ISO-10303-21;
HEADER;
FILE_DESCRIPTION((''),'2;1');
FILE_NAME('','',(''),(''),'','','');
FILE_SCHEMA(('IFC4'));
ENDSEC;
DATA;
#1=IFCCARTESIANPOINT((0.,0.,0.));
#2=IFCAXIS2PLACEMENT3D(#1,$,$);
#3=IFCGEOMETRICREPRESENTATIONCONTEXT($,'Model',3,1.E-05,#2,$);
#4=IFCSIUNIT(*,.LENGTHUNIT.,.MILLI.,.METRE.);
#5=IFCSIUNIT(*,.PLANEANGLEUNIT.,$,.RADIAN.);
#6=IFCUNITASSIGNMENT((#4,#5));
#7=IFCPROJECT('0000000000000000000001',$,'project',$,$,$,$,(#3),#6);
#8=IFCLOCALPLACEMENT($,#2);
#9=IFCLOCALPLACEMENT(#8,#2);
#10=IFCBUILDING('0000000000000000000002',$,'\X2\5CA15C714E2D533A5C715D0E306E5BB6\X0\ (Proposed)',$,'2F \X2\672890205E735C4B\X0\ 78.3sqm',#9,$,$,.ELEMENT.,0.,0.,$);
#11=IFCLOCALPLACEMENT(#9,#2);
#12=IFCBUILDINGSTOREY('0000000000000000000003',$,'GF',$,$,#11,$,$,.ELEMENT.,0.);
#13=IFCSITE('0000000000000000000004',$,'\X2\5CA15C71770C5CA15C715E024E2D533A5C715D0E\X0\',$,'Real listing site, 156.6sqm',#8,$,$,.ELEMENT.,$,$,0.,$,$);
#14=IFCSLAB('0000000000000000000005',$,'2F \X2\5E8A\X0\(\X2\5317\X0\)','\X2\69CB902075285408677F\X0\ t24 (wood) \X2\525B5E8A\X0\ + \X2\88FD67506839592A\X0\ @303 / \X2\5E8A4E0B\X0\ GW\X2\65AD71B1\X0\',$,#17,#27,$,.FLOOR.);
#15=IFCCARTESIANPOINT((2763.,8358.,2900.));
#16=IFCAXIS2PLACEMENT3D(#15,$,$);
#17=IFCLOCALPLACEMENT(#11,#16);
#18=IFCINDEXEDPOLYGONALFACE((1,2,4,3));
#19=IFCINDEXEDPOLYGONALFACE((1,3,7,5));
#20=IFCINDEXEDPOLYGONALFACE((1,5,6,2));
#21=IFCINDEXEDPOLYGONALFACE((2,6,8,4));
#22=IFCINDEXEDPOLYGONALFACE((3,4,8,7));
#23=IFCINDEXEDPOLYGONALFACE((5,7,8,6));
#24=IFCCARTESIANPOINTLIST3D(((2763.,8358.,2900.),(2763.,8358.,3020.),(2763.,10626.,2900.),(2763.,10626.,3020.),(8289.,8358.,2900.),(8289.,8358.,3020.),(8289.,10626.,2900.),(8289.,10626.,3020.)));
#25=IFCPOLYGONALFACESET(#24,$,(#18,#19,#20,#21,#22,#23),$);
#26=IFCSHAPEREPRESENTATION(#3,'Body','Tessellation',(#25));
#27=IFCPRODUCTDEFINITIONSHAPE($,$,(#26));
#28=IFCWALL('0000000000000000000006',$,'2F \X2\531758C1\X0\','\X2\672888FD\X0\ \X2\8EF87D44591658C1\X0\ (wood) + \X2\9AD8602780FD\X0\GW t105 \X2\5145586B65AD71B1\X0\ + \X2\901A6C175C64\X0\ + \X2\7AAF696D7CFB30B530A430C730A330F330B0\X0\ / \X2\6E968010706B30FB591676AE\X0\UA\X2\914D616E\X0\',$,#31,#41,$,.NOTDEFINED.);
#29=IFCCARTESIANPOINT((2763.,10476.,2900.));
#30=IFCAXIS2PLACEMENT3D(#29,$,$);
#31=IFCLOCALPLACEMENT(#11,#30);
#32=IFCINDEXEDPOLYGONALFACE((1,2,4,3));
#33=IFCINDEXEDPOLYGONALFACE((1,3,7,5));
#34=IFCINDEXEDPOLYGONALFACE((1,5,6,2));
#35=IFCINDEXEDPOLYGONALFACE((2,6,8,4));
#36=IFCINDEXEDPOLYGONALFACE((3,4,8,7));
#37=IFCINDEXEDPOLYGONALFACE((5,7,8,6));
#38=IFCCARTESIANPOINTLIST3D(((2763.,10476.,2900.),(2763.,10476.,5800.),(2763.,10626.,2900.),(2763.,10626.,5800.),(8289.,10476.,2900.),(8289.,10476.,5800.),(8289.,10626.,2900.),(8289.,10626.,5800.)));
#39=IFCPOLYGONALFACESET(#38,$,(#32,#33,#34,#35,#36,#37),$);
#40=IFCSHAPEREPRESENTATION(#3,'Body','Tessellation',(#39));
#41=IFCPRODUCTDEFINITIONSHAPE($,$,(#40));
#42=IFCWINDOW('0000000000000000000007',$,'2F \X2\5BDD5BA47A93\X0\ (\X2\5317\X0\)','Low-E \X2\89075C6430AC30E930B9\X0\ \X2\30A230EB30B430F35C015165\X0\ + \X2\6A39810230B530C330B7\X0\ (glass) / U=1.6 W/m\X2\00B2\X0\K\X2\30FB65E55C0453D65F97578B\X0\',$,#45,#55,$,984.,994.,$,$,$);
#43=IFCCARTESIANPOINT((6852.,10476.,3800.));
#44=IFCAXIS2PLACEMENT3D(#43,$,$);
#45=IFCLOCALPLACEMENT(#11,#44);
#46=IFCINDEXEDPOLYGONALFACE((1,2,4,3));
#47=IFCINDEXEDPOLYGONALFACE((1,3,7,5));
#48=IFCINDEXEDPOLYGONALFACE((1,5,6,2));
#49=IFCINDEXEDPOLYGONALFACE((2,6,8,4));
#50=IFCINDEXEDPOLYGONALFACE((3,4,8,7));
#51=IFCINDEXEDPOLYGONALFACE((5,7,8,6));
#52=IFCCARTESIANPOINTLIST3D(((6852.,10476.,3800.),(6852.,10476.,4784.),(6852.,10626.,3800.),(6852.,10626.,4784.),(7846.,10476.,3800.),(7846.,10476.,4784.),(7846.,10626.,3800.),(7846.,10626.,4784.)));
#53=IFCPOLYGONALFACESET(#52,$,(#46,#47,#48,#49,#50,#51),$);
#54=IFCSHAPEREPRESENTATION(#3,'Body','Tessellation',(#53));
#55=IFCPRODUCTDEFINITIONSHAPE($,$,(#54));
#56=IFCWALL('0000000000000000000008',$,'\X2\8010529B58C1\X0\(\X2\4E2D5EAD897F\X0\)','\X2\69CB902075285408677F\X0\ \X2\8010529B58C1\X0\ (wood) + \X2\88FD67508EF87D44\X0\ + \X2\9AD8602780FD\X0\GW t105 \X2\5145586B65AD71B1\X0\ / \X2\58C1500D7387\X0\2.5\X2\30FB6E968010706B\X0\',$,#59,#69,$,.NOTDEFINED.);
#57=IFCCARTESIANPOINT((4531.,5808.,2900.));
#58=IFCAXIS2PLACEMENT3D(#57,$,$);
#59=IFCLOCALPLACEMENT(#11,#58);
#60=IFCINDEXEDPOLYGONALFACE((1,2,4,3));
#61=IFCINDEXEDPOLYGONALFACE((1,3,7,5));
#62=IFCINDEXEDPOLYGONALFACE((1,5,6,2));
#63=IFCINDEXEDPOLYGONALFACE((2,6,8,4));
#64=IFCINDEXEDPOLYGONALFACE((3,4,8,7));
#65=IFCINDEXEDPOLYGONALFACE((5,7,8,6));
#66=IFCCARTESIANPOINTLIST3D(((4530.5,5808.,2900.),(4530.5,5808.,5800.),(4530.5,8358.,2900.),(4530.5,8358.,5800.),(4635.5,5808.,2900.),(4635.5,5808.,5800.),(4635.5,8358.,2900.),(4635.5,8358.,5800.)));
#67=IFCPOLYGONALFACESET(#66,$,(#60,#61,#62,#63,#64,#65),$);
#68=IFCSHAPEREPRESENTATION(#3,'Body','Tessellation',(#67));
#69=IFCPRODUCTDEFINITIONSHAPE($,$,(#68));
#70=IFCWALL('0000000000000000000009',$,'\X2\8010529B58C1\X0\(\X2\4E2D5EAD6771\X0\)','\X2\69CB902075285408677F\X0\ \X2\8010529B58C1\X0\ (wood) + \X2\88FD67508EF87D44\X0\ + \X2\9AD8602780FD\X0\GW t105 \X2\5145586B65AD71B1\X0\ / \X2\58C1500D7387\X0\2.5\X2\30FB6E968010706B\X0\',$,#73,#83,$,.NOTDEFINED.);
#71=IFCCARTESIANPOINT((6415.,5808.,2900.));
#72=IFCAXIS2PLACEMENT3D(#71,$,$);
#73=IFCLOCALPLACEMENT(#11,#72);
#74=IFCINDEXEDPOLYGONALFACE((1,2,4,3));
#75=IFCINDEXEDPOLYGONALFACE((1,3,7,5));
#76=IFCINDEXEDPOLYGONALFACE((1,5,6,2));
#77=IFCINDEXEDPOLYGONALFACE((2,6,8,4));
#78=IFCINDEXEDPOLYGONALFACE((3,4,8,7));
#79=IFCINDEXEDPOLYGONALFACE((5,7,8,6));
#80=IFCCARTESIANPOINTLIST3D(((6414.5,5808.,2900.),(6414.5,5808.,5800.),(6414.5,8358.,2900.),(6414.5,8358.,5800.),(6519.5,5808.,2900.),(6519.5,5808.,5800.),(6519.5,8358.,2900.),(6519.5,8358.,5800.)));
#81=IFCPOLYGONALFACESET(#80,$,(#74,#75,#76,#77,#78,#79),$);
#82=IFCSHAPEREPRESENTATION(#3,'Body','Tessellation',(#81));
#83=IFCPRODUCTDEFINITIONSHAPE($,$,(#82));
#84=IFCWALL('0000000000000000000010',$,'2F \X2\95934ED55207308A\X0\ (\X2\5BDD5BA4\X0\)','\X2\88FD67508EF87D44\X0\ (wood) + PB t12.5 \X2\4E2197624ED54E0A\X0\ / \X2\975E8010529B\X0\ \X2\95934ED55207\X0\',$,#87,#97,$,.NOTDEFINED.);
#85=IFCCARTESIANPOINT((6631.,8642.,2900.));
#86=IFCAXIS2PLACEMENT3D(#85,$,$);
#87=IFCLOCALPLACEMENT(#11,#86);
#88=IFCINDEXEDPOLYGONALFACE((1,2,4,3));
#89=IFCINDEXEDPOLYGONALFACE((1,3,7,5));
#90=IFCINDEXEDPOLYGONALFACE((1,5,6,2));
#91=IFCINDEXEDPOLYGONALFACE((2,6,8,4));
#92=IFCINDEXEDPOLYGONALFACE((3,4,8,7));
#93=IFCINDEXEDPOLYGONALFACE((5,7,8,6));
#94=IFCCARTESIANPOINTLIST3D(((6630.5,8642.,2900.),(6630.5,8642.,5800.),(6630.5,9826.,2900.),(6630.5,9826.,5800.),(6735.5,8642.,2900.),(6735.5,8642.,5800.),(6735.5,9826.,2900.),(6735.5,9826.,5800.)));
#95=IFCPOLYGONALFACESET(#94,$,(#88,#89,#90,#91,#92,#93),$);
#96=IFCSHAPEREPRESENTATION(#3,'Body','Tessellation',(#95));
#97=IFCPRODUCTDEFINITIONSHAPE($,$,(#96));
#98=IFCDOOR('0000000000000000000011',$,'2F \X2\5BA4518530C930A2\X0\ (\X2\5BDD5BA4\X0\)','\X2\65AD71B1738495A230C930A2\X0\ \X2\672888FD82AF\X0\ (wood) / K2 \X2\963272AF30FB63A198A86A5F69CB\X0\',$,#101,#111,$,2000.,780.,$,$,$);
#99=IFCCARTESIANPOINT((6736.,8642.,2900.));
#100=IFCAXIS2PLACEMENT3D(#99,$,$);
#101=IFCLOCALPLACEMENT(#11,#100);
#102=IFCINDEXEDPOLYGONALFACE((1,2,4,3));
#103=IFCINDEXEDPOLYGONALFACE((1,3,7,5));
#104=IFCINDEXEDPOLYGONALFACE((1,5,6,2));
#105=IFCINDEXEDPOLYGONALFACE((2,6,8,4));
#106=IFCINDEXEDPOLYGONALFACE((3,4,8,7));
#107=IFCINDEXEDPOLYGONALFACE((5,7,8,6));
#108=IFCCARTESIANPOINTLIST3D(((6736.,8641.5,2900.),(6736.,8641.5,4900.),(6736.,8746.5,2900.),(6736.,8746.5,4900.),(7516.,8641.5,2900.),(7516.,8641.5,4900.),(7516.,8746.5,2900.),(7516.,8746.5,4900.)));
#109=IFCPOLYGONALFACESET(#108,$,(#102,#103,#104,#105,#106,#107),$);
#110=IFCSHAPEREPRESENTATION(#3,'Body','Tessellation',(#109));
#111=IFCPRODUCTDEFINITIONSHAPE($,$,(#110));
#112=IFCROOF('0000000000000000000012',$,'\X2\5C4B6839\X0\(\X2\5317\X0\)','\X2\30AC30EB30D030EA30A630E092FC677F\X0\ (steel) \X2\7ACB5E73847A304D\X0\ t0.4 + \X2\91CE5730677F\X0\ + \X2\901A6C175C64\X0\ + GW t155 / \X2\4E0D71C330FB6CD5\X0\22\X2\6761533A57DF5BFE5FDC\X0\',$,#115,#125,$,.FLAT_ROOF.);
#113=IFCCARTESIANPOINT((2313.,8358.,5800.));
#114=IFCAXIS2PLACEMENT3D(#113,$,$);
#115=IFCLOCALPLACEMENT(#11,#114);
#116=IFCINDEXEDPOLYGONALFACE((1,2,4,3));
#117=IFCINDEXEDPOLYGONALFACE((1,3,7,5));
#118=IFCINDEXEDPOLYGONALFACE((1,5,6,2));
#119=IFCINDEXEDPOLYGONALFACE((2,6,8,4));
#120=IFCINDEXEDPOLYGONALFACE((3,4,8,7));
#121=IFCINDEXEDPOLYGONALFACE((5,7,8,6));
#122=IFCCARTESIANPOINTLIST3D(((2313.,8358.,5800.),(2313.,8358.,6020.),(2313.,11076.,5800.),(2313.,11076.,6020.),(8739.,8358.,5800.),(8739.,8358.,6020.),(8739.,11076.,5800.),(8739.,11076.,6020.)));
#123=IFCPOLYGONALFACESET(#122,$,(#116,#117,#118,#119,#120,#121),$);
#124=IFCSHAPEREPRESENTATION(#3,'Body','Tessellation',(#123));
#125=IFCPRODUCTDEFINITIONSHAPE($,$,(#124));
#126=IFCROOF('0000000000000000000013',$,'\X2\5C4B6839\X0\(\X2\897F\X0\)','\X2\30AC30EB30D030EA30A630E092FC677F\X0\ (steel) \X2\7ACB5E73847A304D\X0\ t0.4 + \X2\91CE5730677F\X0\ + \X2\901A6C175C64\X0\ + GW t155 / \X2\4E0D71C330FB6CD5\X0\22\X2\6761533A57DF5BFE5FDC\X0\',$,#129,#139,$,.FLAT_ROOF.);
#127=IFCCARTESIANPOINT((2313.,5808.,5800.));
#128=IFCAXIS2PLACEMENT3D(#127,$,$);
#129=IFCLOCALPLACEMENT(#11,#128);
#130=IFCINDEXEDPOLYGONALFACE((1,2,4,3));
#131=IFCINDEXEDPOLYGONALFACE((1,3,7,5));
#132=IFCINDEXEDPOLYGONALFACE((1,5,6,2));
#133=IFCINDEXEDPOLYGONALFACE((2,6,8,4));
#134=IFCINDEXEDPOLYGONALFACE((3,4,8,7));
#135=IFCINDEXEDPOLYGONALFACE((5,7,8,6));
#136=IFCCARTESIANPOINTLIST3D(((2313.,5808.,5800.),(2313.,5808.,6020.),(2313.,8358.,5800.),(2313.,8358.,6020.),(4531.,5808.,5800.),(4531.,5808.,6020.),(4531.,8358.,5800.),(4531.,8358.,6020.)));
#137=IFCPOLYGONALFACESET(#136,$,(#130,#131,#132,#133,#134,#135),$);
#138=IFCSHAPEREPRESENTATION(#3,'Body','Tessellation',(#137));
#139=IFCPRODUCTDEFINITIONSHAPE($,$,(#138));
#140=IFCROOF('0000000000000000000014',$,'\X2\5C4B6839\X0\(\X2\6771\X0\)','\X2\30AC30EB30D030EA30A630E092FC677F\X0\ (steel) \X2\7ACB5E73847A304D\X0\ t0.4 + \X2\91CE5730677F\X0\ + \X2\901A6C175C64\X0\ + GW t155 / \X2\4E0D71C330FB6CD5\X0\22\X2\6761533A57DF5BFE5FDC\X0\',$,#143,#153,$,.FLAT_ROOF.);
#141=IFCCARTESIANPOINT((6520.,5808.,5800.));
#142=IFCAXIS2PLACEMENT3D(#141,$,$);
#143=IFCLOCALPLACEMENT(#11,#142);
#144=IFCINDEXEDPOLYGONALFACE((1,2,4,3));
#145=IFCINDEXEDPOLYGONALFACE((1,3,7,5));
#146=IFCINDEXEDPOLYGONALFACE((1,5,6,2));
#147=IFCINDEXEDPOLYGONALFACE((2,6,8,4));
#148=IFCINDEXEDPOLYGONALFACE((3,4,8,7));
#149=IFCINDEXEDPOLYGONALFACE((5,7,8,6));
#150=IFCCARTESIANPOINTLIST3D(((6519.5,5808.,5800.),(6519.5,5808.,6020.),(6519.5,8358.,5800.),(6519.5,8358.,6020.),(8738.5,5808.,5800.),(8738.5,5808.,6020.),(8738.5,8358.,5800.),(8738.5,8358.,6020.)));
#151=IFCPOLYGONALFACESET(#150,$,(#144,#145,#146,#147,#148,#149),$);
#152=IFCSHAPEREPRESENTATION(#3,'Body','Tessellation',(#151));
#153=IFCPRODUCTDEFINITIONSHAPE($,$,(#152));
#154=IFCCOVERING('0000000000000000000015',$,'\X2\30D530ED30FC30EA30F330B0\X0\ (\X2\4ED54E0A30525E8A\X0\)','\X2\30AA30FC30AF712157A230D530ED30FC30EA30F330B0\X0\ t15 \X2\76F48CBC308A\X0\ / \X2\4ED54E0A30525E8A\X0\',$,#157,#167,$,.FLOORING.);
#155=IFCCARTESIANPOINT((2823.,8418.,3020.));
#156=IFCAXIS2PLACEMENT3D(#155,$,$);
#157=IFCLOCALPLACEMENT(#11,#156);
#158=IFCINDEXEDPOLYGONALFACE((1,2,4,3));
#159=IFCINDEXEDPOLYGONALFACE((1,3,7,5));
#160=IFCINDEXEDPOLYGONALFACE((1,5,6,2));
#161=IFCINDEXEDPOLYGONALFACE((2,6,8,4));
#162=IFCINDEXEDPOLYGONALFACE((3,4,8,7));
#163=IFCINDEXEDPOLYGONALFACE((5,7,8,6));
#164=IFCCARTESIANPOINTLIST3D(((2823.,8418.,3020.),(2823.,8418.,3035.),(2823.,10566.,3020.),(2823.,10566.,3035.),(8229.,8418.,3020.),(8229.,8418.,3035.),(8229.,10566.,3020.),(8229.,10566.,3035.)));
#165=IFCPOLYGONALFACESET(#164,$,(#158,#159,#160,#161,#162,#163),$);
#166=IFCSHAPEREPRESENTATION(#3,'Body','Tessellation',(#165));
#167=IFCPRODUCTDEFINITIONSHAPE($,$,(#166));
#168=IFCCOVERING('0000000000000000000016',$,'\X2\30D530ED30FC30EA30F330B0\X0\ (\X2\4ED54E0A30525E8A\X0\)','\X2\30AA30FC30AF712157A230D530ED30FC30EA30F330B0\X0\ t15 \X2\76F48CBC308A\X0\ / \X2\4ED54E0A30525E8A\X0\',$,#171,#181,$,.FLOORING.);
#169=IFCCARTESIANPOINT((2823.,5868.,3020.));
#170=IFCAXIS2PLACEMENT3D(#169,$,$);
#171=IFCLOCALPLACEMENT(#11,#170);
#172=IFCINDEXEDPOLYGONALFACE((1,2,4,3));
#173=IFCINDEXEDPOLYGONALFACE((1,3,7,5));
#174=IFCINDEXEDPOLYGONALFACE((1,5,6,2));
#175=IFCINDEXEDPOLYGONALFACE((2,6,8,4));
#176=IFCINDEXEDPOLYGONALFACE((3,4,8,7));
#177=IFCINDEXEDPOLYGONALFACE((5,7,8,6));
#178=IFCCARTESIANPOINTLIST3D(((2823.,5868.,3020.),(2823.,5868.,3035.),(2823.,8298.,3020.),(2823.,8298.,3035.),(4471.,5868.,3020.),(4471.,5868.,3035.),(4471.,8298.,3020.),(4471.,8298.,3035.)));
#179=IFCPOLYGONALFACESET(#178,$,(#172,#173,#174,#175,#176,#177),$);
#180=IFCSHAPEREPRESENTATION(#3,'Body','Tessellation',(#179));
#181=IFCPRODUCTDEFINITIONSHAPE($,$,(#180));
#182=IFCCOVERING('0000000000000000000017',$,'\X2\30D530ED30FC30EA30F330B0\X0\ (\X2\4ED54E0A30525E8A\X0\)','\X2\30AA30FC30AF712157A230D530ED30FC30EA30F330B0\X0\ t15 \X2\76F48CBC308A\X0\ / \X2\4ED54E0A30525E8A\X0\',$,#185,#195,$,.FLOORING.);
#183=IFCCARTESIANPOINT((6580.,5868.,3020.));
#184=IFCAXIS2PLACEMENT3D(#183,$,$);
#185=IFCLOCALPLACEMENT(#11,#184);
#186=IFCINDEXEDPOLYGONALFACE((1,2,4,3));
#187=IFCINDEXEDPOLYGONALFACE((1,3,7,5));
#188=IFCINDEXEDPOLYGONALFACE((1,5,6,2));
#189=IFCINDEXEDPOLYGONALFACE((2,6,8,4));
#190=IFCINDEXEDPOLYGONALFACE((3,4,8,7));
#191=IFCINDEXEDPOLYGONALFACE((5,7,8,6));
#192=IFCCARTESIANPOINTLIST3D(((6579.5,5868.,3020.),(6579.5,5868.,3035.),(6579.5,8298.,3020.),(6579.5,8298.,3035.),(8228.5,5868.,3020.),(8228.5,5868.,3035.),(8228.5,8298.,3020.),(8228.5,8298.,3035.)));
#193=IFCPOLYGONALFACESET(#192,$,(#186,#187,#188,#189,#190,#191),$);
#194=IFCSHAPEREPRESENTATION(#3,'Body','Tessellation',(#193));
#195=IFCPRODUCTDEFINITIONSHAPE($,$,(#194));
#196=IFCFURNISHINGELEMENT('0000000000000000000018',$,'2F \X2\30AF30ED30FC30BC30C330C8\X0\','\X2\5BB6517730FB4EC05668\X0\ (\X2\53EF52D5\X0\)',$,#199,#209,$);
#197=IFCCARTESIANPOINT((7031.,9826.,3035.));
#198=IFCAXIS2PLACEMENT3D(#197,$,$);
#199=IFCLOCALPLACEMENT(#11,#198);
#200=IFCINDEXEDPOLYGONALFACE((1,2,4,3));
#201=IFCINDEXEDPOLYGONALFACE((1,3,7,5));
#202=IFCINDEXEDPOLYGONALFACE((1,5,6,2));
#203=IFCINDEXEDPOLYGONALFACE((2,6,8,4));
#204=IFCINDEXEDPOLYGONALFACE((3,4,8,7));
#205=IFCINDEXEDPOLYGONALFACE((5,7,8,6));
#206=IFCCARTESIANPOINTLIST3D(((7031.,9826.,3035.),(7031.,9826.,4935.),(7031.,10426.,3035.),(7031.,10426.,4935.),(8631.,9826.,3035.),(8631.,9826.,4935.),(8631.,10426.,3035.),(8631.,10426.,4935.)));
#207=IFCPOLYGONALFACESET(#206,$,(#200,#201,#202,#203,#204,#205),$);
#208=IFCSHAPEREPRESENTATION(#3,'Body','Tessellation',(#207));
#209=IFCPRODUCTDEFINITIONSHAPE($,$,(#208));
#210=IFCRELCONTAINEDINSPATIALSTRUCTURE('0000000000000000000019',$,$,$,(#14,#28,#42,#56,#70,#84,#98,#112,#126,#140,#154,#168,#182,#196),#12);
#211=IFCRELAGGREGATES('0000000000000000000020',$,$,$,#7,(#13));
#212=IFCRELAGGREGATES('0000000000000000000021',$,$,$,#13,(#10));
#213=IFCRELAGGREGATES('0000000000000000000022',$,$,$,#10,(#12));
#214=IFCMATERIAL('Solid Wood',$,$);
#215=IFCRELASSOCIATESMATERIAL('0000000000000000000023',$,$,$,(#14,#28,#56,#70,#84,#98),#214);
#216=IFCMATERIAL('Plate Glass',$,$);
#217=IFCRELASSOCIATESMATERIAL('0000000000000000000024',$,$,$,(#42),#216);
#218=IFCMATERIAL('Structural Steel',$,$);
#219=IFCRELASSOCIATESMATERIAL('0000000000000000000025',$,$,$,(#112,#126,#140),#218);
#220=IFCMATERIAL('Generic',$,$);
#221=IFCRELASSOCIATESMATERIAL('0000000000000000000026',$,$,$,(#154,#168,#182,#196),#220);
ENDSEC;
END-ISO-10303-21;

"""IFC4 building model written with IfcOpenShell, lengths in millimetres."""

from ifc_helpers import new_model, si_unit, frame, frame_2d, origin, place, context, project, spatial, rectangle, extrude, material, element, fill, save


model = new_model("IFC4")

# Units and contexts
model_context = context("Model", 3, precision=1e-05, world=origin())
ifc_project = project(units=[si_unit("LENGTHUNIT", "METRE", prefix="MILLI"), si_unit("PLANEANGLEUNIT", "RADIAN")], contexts=[model_context])

# Site, building, storey
site_placement = place(None, origin())
site = spatial("IfcSite", under=ifc_project, at=site_placement, Name="岡山県岡山市中区山崎", ObjectType="Real listing site, 156.6sqm", CompositionType="ELEMENT", RefElevation=0.0)
building_placement = place(site_placement, origin())
building = spatial("IfcBuilding", under=site, at=building_placement, Name="岡山中区山崎の家 (Proposed)", ObjectType="2F 木造平屋 78.3sqm", CompositionType="ELEMENT", ElevationOfRefHeight=0.0, ElevationOfTerrain=0.0)
storey_placement = place(building_placement, origin())
storey = spatial("IfcBuildingStorey", under=building, at=storey_placement, Name="GF", CompositionType="ELEMENT", Elevation=0.0)

# Slab
ifc_material_1 = material(Name="Solid Wood")
slab_placement = place(storey_placement, frame((2763.0, 8358.0, 2900.0)))
element("IfcSlab", 1, at=slab_placement, inside=storey, material=ifc_material_1, Name="2F 床(北)", Description="構造用合板 t24 (wood) 剛床 + 製材根太 @303 / 床下 GW断熱", PredefinedType="FLOOR", context=model_context, shape_type="SweptSolid", body=[
    extrude(rectangle(XDim=5526.0, YDim=2268.0, at=frame_2d((2763.0, 1134.0))), frame((2763.0, 8358.0, 2900.0)), (0.0, 0.0, 1.0), 120.0),
])

# Wall, opening, window
wall_1_placement = place(storey_placement, frame((2763.0, 10476.0, 2900.0)))
wall_1 = element("IfcWall", 2, at=wall_1_placement, inside=storey, material=ifc_material_1, Name="2F 北壁", Description="木製 軸組外壁 (wood) + 高性能GW t105 充填断熱 + 通気層 + 窯業系サイディング / 準耐火・外皮UA配慮", PredefinedType="NOTDEFINED", context=model_context, shape_type="SweptSolid", body=[
    extrude(rectangle(XDim=5526.0, YDim=150.0, at=frame_2d((2763.0, 75.0))), frame((2763.0, 10476.0, 2900.0)), (0.0, 0.0, 1.0), 2900.0),
])
opening_1_placement = place(storey_placement, frame((6852.0, 10476.0, 3800.0)))
opening_1 = element("IfcOpeningElement", 3, at=opening_1_placement, cuts=wall_1, PredefinedType="NOTDEFINED", context=model_context, shape_type="SweptSolid", body=[
    extrude(rectangle(XDim=994.0, YDim=150.0, at=frame_2d((497.0, 75.0))), frame((6852.0, 10476.0, 3800.0)), (0.0, 0.0, 1.0), 984.0),
])
ifc_material_2 = material(Name="Plate Glass")
window_1_placement = place(storey_placement, frame((6852.0, 10476.0, 3800.0)))
window_1 = element("IfcWindow", 4, at=window_1_placement, inside=storey, material=ifc_material_2, Name="2F 寝室窓 (北)", Description="Low-E 複層ガラス アルゴン封入 + 樹脂サッシ (glass) / U=1.6 W/m²K・日射取得型", OverallHeight=984.0, OverallWidth=994.0, context=model_context, shape_type="SweptSolid", body=[
    extrude(rectangle(XDim=994.0, YDim=150.0, at=frame_2d((497.0, 75.0))), frame((6852.0, 10476.0, 3800.0)), (0.0, 0.0, 1.0), 984.0),
])
fill(opening_1, window_1)

# Walls
wall_2_placement = place(storey_placement, frame((4531.0, 5808.0, 2900.0)))
element("IfcWall", 5, at=wall_2_placement, inside=storey, material=ifc_material_1, Name="耐力壁(中庭西)", Description="構造用合板 耐力壁 (wood) + 製材軸組 + 高性能GW t105 充填断熱 / 壁倍率2.5・準耐火", PredefinedType="NOTDEFINED", context=model_context, shape_type="SweptSolid", body=[
    extrude(rectangle(XDim=105.0, YDim=2550.0, at=frame_2d((52.0, 1275.0))), frame((4531.0, 5808.0, 2900.0)), (0.0, 0.0, 1.0), 2900.0),
])
wall_3_placement = place(storey_placement, frame((6415.0, 5808.0, 2900.0)))
element("IfcWall", 6, at=wall_3_placement, inside=storey, material=ifc_material_1, Name="耐力壁(中庭東)", Description="構造用合板 耐力壁 (wood) + 製材軸組 + 高性能GW t105 充填断熱 / 壁倍率2.5・準耐火", PredefinedType="NOTDEFINED", context=model_context, shape_type="SweptSolid", body=[
    extrude(rectangle(XDim=105.0, YDim=2550.0, at=frame_2d((52.0, 1275.0))), frame((6415.0, 5808.0, 2900.0)), (0.0, 0.0, 1.0), 2900.0),
])
wall_4_placement = place(storey_placement, frame((6631.0, 8642.0, 2900.0)))
element("IfcWall", 7, at=wall_4_placement, inside=storey, material=ifc_material_1, Name="2F 間仕切り (寝室)", Description="製材軸組 (wood) + PB t12.5 両面仕上 / 非耐力 間仕切", PredefinedType="NOTDEFINED", context=model_context, shape_type="SweptSolid", body=[
    extrude(rectangle(XDim=105.0, YDim=1184.0, at=frame_2d((52.0, 592.0))), frame((6631.0, 8642.0, 2900.0)), (0.0, 0.0, 1.0), 2900.0),
])

# Door
door_placement = place(storey_placement, frame((6736.0, 8642.0, 2900.0)))
element("IfcDoor", 8, at=door_placement, inside=storey, material=ifc_material_1, Name="2F 室内ドア (寝室)", Description="断熱玄関ドア 木製芯 (wood) / K2 防犯・採風機構", OverallHeight=2000.0, OverallWidth=780.0, context=model_context, shape_type="SweptSolid", body=[
    extrude(rectangle(XDim=780.0, YDim=105.0, at=frame_2d((390.0, 52.0))), frame((6736.0, 8642.0, 2900.0)), (0.0, 0.0, 1.0), 2000.0),
])

# Roofs
ifc_material_3 = material(Name="Structural Steel")
for number, where, name in (
    (9, (2313.0, 8358.0, 5800.0), "屋根(北)"),
):
    element("IfcRoof", number, at=place(storey_placement, frame(where)), inside=storey, material=ifc_material_3, Name=name, Description="ガルバリウム鋼板 (steel) 立平葺き t0.4 + 野地板 + 通気層 + GW t155 / 不燃・法22条区域対応", PredefinedType="FLAT_ROOF", context=model_context, shape_type="SweptSolid", body=[
        extrude(rectangle(XDim=6426.0, YDim=2718.0, at=frame_2d((3213.0, 1359.0))), frame((2313.0, 8358.0, 5800.0)), (0.0, 0.0, 1.0), 220.0),
    ])
roof_1_placement = place(storey_placement, frame((2313.0, 5808.0, 5800.0)))
element("IfcRoof", 10, at=roof_1_placement, inside=storey, material=ifc_material_3, Name="屋根(西)", Description="ガルバリウム鋼板 (steel) 立平葺き t0.4 + 野地板 + 通気層 + GW t155 / 不燃・法22条区域対応", PredefinedType="FLAT_ROOF", context=model_context, shape_type="SweptSolid", body=[
    extrude(rectangle(XDim=2218.0, YDim=2550.0, at=frame_2d((1109.0, 1275.0))), frame((2313.0, 5808.0, 5800.0)), (0.0, 0.0, 1.0), 220.0),
])
roof_2_placement = place(storey_placement, frame((6520.0, 5808.0, 5800.0)))
element("IfcRoof", 11, at=roof_2_placement, inside=storey, material=ifc_material_3, Name="屋根(東)", Description="ガルバリウム鋼板 (steel) 立平葺き t0.4 + 野地板 + 通気層 + GW t155 / 不燃・法22条区域対応", PredefinedType="FLAT_ROOF", context=model_context, shape_type="SweptSolid", body=[
    extrude(rectangle(XDim=2219.0, YDim=2550.0, at=frame_2d((1109.0, 1275.0))), frame((6520.0, 5808.0, 5800.0)), (0.0, 0.0, 1.0), 220.0),
])

# Coverings
ifc_material_4 = material(Name="Generic")
covering_1_placement = place(storey_placement, frame((2823.0, 8418.0, 3020.0)))
element("IfcCovering", 12, at=covering_1_placement, inside=storey, material=ifc_material_4, Name="フローリング (仕上げ床)", Description="オーク無垢フローリング t15 直貼り / 仕上げ床", PredefinedType="FLOORING", context=model_context, shape_type="SweptSolid", body=[
    extrude(rectangle(XDim=5406.0, YDim=2148.0, at=frame_2d((2703.0, 1074.0))), frame((2823.0, 8418.0, 3020.0)), (0.0, 0.0, 1.0), 15.0),
])
covering_2_placement = place(storey_placement, frame((2823.0, 5868.0, 3020.0)))
element("IfcCovering", 13, at=covering_2_placement, inside=storey, material=ifc_material_4, Name="フローリング (仕上げ床)", Description="オーク無垢フローリング t15 直貼り / 仕上げ床", PredefinedType="FLOORING", context=model_context, shape_type="SweptSolid", body=[
    extrude(rectangle(XDim=1648.0, YDim=2430.0, at=frame_2d((824.0, 1215.0))), frame((2823.0, 5868.0, 3020.0)), (0.0, 0.0, 1.0), 15.0),
])
covering_3_placement = place(storey_placement, frame((6580.0, 5868.0, 3020.0)))
element("IfcCovering", 14, at=covering_3_placement, inside=storey, material=ifc_material_4, Name="フローリング (仕上げ床)", Description="オーク無垢フローリング t15 直貼り / 仕上げ床", PredefinedType="FLOORING", context=model_context, shape_type="SweptSolid", body=[
    extrude(rectangle(XDim=1649.0, YDim=2430.0, at=frame_2d((824.0, 1215.0))), frame((6580.0, 5868.0, 3020.0)), (0.0, 0.0, 1.0), 15.0),
])

# Furnishing element
furnishing_1_placement = place(storey_placement, frame((7031.0, 9826.0, 3035.0)))
element("IfcFurnishingElement", 15, at=furnishing_1_placement, inside=storey, material=ifc_material_4, Name="2F クローゼット", Description="家具・什器 (可動)", context=model_context, shape_type="SweptSolid", body=[
    extrude(rectangle(XDim=1600.0, YDim=600.0, at=frame_2d((800.0, 300.0))), frame((7031.0, 9826.0, 3035.0)), (0.0, 0.0, 1.0), 1900.0),
])

save(model, "model.ifc")
